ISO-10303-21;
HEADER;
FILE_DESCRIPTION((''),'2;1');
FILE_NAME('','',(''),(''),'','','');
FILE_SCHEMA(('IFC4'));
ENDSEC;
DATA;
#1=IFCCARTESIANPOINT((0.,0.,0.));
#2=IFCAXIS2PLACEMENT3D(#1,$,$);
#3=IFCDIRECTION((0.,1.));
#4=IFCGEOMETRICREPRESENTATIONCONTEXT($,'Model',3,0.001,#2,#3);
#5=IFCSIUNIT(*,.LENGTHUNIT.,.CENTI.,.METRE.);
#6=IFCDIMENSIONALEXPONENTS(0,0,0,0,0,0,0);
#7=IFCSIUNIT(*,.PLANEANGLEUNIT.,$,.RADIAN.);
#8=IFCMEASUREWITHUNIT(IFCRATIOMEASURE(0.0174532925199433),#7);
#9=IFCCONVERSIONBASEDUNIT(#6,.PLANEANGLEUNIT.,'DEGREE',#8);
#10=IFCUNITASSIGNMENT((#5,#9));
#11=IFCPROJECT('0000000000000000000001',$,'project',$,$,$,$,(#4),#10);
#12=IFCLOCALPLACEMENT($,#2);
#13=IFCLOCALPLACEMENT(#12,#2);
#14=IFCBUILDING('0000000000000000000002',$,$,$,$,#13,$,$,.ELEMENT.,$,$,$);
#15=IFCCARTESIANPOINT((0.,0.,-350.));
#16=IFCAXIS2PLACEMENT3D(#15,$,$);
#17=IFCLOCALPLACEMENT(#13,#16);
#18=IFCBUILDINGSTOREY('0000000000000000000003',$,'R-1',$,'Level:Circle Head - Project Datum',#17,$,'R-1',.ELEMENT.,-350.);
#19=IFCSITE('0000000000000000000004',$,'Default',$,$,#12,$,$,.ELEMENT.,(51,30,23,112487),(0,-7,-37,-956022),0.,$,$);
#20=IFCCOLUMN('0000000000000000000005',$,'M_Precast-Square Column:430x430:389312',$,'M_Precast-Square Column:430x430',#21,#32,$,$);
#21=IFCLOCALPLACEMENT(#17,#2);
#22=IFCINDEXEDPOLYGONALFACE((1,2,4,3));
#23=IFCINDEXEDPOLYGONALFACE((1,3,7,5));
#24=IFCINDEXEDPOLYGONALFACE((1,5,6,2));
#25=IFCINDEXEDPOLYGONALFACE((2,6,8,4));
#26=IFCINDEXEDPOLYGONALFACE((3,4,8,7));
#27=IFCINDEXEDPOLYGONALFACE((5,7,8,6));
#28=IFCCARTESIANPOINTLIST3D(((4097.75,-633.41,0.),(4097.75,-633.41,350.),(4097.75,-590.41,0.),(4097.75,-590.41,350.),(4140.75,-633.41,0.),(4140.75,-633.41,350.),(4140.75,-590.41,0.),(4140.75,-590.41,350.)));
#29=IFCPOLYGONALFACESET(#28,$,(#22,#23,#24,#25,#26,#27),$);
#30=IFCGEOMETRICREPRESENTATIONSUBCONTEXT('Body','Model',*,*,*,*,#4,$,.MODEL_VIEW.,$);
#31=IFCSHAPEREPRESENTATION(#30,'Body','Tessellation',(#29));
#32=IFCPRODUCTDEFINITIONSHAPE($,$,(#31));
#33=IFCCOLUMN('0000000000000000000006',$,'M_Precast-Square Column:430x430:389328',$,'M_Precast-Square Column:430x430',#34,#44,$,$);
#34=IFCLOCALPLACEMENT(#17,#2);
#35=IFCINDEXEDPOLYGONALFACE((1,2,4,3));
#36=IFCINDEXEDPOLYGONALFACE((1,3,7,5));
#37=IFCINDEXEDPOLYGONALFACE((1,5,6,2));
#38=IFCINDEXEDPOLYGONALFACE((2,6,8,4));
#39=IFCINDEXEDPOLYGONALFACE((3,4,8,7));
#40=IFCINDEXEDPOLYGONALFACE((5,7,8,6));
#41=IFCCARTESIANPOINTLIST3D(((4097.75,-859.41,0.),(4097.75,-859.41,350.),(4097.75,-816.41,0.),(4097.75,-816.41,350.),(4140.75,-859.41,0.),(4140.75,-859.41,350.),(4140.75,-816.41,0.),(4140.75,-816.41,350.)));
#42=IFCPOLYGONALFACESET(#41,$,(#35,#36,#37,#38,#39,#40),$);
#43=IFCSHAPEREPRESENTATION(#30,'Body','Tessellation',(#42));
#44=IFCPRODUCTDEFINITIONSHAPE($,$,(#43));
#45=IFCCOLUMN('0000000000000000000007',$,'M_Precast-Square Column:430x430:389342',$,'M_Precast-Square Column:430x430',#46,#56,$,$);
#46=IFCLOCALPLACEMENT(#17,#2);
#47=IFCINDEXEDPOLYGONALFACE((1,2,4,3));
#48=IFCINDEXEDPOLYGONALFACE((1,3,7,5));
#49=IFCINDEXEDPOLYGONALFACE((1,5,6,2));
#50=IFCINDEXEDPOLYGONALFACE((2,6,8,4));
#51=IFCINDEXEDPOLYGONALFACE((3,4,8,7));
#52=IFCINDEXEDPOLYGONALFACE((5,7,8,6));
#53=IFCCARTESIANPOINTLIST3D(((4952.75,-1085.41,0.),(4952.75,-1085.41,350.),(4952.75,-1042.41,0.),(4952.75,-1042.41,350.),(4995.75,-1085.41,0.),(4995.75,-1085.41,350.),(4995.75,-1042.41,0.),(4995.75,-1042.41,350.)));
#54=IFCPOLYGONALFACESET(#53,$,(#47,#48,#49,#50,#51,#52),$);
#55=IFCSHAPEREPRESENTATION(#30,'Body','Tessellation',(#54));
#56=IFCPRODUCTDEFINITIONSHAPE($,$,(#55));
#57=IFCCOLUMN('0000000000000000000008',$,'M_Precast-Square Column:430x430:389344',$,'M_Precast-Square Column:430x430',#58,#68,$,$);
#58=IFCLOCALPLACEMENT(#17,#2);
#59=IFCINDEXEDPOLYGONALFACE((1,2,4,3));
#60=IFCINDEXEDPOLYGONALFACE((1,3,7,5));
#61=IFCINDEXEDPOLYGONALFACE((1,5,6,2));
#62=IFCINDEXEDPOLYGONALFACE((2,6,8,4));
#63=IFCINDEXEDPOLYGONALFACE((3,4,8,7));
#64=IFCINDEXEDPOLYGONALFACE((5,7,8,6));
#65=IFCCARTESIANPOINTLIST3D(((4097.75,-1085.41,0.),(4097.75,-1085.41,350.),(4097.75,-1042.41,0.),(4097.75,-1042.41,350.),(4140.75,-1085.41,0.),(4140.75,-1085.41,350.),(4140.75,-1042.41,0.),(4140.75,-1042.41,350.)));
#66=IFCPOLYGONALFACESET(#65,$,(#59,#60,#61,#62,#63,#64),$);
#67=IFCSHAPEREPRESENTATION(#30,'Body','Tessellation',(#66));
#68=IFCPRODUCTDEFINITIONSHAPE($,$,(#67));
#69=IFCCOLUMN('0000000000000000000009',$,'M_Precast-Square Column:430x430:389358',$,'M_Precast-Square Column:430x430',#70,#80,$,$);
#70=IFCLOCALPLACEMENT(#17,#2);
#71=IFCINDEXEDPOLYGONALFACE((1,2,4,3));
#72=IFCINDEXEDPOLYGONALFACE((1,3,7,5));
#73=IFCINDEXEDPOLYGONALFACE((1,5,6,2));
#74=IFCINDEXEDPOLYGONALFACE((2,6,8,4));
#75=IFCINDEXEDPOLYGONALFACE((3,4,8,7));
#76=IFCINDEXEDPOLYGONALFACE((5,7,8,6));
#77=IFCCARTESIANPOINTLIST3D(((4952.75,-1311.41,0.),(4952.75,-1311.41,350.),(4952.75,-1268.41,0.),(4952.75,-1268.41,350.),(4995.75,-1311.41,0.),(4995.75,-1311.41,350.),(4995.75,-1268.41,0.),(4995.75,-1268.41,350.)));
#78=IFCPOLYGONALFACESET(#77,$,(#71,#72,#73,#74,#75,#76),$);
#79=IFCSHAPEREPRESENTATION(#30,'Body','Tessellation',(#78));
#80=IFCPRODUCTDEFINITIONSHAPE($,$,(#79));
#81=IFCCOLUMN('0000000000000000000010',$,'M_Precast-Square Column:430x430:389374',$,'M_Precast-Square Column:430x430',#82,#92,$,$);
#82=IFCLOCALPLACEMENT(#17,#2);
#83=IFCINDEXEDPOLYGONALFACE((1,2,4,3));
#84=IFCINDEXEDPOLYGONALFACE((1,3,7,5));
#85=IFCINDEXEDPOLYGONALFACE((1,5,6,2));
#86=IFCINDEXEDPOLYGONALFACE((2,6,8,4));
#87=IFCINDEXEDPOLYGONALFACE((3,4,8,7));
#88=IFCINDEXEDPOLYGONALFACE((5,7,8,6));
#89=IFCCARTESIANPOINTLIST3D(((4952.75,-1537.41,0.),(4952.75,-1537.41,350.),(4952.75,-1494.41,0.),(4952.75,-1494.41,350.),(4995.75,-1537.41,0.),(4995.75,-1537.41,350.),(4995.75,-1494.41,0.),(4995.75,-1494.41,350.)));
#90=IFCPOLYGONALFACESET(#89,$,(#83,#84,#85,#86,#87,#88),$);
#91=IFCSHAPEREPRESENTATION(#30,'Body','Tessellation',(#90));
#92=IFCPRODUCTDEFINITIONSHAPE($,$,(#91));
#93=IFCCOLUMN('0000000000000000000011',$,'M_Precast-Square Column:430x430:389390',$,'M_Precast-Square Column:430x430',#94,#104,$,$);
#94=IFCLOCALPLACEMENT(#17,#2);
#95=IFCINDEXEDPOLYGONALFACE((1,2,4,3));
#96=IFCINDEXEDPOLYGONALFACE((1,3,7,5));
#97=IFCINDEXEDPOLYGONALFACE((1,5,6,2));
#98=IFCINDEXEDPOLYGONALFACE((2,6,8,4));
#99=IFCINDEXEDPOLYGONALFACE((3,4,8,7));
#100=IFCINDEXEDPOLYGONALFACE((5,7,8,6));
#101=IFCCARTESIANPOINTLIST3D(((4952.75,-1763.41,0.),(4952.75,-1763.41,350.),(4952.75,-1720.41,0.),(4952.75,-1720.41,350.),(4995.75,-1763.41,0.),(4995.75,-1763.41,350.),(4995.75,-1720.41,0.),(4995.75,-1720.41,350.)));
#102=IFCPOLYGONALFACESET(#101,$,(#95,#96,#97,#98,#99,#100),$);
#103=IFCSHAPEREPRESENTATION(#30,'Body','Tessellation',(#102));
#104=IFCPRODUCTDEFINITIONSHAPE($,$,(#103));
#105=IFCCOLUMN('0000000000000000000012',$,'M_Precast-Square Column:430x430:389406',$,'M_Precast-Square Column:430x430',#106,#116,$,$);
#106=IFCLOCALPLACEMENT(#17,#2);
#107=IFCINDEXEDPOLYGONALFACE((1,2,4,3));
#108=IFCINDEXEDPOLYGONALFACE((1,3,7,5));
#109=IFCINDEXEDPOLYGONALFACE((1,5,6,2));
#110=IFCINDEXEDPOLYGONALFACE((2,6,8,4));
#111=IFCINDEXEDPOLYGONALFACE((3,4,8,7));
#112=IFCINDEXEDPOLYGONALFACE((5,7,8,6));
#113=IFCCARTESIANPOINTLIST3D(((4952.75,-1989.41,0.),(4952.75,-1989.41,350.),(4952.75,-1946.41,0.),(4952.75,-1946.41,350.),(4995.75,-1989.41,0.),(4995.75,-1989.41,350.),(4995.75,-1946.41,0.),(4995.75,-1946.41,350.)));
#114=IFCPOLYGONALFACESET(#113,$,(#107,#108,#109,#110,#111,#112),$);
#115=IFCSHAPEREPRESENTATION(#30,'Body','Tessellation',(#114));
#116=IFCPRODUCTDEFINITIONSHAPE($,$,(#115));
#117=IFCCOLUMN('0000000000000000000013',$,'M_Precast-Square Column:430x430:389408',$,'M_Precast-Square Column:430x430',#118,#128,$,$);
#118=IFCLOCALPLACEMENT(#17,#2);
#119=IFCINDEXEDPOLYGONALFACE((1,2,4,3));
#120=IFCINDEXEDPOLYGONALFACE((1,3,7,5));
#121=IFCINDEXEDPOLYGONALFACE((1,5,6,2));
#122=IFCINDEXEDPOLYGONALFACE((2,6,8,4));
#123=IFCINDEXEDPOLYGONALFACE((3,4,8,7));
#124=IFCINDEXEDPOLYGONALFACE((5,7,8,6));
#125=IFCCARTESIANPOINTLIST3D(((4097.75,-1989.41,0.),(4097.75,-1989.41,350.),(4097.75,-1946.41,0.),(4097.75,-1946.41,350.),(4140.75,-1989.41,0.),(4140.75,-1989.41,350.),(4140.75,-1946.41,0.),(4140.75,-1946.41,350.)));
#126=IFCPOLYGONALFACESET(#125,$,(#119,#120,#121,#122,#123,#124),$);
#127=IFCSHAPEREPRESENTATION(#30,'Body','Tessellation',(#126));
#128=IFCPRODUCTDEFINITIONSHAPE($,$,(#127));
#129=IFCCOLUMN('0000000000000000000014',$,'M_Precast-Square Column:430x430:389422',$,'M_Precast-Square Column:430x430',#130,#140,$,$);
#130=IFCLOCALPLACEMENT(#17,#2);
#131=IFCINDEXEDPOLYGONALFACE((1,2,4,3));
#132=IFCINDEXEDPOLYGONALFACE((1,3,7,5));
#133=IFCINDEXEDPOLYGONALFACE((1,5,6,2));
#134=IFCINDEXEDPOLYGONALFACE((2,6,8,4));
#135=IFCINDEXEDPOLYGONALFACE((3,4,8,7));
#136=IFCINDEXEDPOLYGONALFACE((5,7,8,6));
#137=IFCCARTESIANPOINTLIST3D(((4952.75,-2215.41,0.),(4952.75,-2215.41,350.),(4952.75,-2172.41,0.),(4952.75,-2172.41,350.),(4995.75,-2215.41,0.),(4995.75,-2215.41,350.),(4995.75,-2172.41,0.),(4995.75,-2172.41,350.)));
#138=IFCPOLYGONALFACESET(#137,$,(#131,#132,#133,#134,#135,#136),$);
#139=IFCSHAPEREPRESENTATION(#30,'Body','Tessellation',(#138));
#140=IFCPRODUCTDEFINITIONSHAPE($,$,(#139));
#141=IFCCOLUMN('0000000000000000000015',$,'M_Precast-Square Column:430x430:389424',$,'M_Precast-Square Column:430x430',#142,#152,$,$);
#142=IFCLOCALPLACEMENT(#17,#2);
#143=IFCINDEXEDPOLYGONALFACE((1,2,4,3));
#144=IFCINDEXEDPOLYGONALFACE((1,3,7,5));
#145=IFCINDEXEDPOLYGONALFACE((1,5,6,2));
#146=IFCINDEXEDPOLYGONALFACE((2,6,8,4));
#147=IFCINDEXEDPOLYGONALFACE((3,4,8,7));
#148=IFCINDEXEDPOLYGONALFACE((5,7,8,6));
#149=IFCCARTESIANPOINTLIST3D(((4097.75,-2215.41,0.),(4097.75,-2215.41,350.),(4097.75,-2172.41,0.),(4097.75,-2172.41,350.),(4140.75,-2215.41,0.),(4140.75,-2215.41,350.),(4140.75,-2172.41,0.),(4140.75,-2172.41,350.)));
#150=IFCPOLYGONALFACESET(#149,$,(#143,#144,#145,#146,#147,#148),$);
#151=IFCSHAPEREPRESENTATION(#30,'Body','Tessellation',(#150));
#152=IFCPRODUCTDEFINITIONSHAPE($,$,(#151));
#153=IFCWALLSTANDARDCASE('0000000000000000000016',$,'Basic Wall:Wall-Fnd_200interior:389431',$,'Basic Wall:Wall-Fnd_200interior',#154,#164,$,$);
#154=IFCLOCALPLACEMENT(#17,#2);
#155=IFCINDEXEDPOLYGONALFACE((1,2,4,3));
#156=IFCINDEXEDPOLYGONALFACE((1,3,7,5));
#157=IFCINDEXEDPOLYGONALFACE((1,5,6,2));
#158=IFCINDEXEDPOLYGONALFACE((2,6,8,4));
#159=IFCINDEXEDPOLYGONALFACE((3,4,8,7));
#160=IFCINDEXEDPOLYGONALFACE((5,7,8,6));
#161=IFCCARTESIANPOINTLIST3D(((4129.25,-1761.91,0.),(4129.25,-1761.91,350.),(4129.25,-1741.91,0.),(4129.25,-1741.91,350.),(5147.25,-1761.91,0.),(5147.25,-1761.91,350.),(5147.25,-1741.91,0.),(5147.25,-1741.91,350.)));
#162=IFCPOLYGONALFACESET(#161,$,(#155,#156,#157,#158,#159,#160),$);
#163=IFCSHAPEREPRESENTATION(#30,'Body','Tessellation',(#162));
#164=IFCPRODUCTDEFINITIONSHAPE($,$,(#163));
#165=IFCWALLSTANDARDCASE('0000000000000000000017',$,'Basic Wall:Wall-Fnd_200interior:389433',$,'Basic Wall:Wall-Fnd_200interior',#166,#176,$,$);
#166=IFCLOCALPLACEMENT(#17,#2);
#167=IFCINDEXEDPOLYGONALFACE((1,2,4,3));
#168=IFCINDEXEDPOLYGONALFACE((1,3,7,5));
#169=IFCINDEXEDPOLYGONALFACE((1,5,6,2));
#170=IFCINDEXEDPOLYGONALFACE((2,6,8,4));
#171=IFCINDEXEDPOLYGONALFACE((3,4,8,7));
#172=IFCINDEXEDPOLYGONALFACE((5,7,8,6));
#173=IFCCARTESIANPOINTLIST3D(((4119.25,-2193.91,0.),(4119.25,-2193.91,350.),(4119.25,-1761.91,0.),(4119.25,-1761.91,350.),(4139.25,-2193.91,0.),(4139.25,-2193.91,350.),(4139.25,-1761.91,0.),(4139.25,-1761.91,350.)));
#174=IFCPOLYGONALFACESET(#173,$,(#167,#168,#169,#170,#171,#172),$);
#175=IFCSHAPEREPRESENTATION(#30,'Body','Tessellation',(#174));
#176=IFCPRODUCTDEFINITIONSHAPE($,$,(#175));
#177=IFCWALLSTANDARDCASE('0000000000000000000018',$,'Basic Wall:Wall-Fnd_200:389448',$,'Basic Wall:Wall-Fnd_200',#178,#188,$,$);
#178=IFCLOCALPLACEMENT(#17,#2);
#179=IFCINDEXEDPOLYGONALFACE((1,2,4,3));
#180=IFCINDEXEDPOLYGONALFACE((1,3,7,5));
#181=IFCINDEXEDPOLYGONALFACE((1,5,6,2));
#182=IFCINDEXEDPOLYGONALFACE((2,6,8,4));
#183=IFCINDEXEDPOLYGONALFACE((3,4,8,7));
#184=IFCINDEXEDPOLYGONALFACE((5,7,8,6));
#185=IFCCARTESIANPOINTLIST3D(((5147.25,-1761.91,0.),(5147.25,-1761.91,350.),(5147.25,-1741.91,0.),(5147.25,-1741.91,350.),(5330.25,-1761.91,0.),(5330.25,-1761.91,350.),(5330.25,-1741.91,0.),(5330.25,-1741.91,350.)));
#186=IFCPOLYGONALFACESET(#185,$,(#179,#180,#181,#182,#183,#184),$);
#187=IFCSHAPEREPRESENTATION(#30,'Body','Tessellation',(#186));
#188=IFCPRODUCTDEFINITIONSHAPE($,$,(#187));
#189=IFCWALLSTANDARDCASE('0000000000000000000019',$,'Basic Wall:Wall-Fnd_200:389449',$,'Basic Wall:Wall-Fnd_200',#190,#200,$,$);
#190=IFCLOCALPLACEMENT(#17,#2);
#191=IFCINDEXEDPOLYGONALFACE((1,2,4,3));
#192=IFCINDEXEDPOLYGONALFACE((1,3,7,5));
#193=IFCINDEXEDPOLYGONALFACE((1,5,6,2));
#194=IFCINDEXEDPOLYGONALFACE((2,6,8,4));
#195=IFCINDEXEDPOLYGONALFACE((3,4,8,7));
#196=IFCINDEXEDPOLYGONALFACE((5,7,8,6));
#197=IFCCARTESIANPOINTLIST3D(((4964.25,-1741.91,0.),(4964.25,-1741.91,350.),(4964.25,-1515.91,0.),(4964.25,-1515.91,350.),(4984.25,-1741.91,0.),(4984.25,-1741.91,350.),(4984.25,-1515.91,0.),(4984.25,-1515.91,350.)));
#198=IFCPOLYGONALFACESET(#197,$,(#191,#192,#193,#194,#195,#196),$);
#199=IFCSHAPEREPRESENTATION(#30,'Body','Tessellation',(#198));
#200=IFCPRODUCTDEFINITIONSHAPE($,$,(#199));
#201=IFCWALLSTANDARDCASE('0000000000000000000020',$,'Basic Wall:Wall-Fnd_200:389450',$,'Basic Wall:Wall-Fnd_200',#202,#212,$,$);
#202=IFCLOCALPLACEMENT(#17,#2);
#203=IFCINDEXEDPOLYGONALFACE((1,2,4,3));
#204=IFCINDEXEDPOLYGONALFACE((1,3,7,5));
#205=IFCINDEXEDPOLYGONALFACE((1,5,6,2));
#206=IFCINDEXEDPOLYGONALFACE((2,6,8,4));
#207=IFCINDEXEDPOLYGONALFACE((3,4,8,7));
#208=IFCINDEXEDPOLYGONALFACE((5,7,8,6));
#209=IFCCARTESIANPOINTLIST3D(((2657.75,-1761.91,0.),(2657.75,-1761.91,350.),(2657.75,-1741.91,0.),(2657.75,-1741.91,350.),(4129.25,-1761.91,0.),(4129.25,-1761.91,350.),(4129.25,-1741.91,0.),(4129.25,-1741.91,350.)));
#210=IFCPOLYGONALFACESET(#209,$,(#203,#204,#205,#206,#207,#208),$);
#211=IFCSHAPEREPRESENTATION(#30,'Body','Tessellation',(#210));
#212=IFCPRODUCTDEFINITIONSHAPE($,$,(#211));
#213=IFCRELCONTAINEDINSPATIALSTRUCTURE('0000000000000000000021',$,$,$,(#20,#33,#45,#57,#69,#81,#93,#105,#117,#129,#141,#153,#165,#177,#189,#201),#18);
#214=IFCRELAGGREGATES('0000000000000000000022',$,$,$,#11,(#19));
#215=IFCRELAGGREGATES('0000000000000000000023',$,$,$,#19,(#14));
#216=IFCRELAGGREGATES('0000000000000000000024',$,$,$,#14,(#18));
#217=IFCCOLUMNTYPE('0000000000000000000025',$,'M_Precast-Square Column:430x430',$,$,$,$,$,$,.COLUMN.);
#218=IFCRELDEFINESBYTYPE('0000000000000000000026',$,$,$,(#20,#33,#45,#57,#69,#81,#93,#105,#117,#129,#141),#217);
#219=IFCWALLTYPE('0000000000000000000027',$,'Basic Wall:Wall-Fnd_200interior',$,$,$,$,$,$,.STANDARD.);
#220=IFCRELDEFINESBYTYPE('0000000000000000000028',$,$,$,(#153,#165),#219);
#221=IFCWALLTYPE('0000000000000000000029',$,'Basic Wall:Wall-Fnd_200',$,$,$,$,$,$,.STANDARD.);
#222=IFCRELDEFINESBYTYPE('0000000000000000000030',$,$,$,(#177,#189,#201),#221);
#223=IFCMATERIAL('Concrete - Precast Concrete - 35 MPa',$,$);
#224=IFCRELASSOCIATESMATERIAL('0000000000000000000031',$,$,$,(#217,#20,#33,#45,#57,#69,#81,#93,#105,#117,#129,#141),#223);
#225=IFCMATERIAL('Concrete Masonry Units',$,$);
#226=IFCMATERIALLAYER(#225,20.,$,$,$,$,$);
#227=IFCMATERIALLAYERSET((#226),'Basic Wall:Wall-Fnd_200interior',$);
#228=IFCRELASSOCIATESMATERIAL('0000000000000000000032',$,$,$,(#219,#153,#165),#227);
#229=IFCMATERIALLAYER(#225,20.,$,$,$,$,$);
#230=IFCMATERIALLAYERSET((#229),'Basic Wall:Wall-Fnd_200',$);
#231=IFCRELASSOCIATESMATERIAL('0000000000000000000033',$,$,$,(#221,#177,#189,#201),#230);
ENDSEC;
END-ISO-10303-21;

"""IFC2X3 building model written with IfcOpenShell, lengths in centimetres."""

from ifc_helpers import new_model, entity, si_unit, converted_unit, direction, frame, frame_2d, origin, origin_2d_with_axis, place, context, subcontext, project, spatial, rectangle, extrude, source, transform, mapped, material, layer, layer_set, layer_usage, type_object, type_shapes, element, save


model = new_model("IFC2X3")

# Units and contexts
model_context = context("Model", 3, precision=0.001, world=origin(), true_north=direction((0.0, 1.0)))
body_context = subcontext(model_context, "Body", "Model", "MODEL_VIEW")
ifc_project = project(units=[si_unit("LENGTHUNIT", "METRE", prefix="CENTI"), converted_unit("PLANEANGLEUNIT", "DEGREE", entity("IfcRatioMeasure", 0.0174532925199433), si_unit("PLANEANGLEUNIT", "RADIAN"), dimensions=[0, 0, 0, 0, 0, 0, 0])], contexts=[model_context])

# Site, building, storey
site_placement = place(None, origin())
site = spatial("IfcSite", under=ifc_project, at=site_placement, Name="Default", CompositionType="ELEMENT", RefLatitude=(51, 30, 23, 112487), RefLongitude=(0, -7, -37, -956022), RefElevation=0.0)
building_placement = place(site_placement, origin())
building = spatial("IfcBuilding", under=site, at=building_placement, CompositionType="ELEMENT")
storey_placement = place(building_placement, frame((0.0, 0.0, -350.0)))
storey = spatial("IfcBuildingStorey", under=building, at=storey_placement, Name="R-1", ObjectType="Level:Circle Head - Project Datum", LongName="R-1", CompositionType="ELEMENT", Elevation=-350.0)

# Columns
ifc_material_1 = material(Name="Concrete - Precast Concrete - 35 MPa")
column_type = type_object("IfcColumnType", Name="M_Precast-Square Column:430x430", PredefinedType="COLUMN", material=ifc_material_1)
shared_shape = source(origin(), body_context, "Body", "SweptSolid", [
    extrude(rectangle(XDim=43.0, YDim=43.0, at=origin_2d_with_axis()), frame((0.0, 0.0, -350.0), z_axis=(0.0, 0.0, 1.0), x_axis=(0.0, -1.0, 0.0)), (0.0, 0.0, 1.0), 350.0),
])
type_shapes(column_type, [shared_shape])
for number, where, name in (
    (1, (4119.25, -611.91, 350.0), "M_Precast-Square Column:430x430:389312"),
    (2, (4119.25, -837.91, 350.0), "M_Precast-Square Column:430x430:389328"),
    (3, (4974.25, -1063.91, 350.0), "M_Precast-Square Column:430x430:389342"),
    (4, (4119.25, -1063.91, 350.0), "M_Precast-Square Column:430x430:389344"),
    (5, (4974.25, -1289.91, 350.0), "M_Precast-Square Column:430x430:389358"),
    (6, (4974.25, -1515.91, 350.0), "M_Precast-Square Column:430x430:389374"),
    (7, (4974.25, -1741.91, 350.0), "M_Precast-Square Column:430x430:389390"),
    (8, (4974.25, -1967.91, 350.0), "M_Precast-Square Column:430x430:389406"),
    (9, (4119.25, -1967.91, 350.0), "M_Precast-Square Column:430x430:389408"),
    (10, (4974.25, -2193.91, 350.0), "M_Precast-Square Column:430x430:389422"),
    (11, (4119.25, -2193.91, 350.0), "M_Precast-Square Column:430x430:389424"),
):
    element("IfcColumn", number, at=place(storey_placement, frame(where)), inside=storey, type_object=column_type, material=ifc_material_1, Name=name, ObjectType="M_Precast-Square Column:430x430", context=body_context, shape_type="MappedRepresentation", body=[
        mapped(shared_shape, transform((0.0, 0.0, 0.0), scale=1.0)),
    ])

# Walls
ifc_material_2 = material(Name="Concrete Masonry Units")
ifc_layer_1 = layer(ifc_material_2, 20.0)
ifc_layer_set_1 = layer_set([ifc_layer_1], Name="Basic Wall:Wall-Fnd_200interior")
ifc_layer_usage_1 = layer_usage(ifc_layer_set_1, "AXIS2", "POSITIVE", -10.0)
wall_type_1 = type_object("IfcWallType", Name="Basic Wall:Wall-Fnd_200interior", PredefinedType="STANDARD", material=ifc_layer_set_1)
wall_1_placement = place(storey_placement, frame((5147.25, -1751.91, 0.0), z_axis=(0.0, 0.0, 1.0), x_axis=(-1.0, 0.0, 0.0)))
element("IfcWallStandardCase", 12, at=wall_1_placement, inside=storey, type_object=wall_type_1, material=ifc_layer_usage_1, Name="Basic Wall:Wall-Fnd_200interior:389431", ObjectType="Basic Wall:Wall-Fnd_200interior", context=body_context, shape_type="SweptSolid", body=[
    extrude(rectangle(XDim=1018.0, YDim=20.0, at=frame_2d((509.0, 0.0), x_axis=(-1.0, 0.0))), origin(), (0.0, 0.0, 1.0), 350.0),
])
ifc_layer_usage_2 = layer_usage(ifc_layer_set_1, "AXIS2", "NEGATIVE", 10.0)
wall_2_placement = place(storey_placement, frame((4129.25, -2193.91, 0.0), z_axis=(0.0, 0.0, 1.0), x_axis=(0.0, 1.0, 0.0)))
element("IfcWallStandardCase", 13, at=wall_2_placement, inside=storey, type_object=wall_type_1, material=ifc_layer_usage_2, Name="Basic Wall:Wall-Fnd_200interior:389433", ObjectType="Basic Wall:Wall-Fnd_200interior", context=body_context, shape_type="SweptSolid", body=[
    extrude(rectangle(XDim=432.0, YDim=20.0, at=frame_2d((216.0, 0.0), x_axis=(-1.0, 0.0))), origin(), (0.0, 0.0, 1.0), 350.0),
])
ifc_layer_2 = layer(ifc_material_2, 20.0)
ifc_layer_set_2 = layer_set([ifc_layer_2], Name="Basic Wall:Wall-Fnd_200")
ifc_layer_usage_3 = layer_usage(ifc_layer_set_2, "AXIS2", "NEGATIVE", 10.0)
wall_type_2 = type_object("IfcWallType", Name="Basic Wall:Wall-Fnd_200", PredefinedType="STANDARD", material=ifc_layer_set_2)
wall_3_placement = place(storey_placement, frame((5147.25, -1751.91, 0.0)))
element("IfcWallStandardCase", 14, at=wall_3_placement, inside=storey, type_object=wall_type_2, material=ifc_layer_usage_3, Name="Basic Wall:Wall-Fnd_200:389448", ObjectType="Basic Wall:Wall-Fnd_200", context=body_context, shape_type="SweptSolid", body=[
    extrude(rectangle(XDim=183.0, YDim=20.0, at=frame_2d((91.5, 0.0), x_axis=(-1.0, 0.0))), origin(), (0.0, 0.0, 1.0), 350.0),
])
ifc_layer_usage_4 = layer_usage(ifc_layer_set_2, "AXIS2", "POSITIVE", -10.0)
wall_4_placement = place(storey_placement, frame((4974.25, -1741.91, 0.0), z_axis=(0.0, 0.0, 1.0), x_axis=(0.0, 1.0, 0.0)))
element("IfcWallStandardCase", 15, at=wall_4_placement, inside=storey, type_object=wall_type_2, material=ifc_layer_usage_4, Name="Basic Wall:Wall-Fnd_200:389449", ObjectType="Basic Wall:Wall-Fnd_200", context=body_context, shape_type="SweptSolid", body=[
    extrude(rectangle(XDim=226.0, YDim=20.0, at=frame_2d((113.0, 0.0), x_axis=(-1.0, 0.0))), origin(), (0.0, 0.0, 1.0), 350.0),
])
ifc_layer_usage_5 = layer_usage(ifc_layer_set_2, "AXIS2", "POSITIVE", -10.0)
wall_5_placement = place(storey_placement, frame((4129.25, -1751.91, 0.0), z_axis=(0.0, 0.0, 1.0), x_axis=(-1.0, 0.0, 0.0)))
element("IfcWallStandardCase", 16, at=wall_5_placement, inside=storey, type_object=wall_type_2, material=ifc_layer_usage_5, Name="Basic Wall:Wall-Fnd_200:389450", ObjectType="Basic Wall:Wall-Fnd_200", context=body_context, shape_type="SweptSolid", body=[
    extrude(rectangle(XDim=1471.5, YDim=20.0, at=frame_2d((735.75, 0.0), x_axis=(-1.0, 0.0))), origin(), (0.0, 0.0, 1.0), 350.0),
])

save(model, "model.ifc")
